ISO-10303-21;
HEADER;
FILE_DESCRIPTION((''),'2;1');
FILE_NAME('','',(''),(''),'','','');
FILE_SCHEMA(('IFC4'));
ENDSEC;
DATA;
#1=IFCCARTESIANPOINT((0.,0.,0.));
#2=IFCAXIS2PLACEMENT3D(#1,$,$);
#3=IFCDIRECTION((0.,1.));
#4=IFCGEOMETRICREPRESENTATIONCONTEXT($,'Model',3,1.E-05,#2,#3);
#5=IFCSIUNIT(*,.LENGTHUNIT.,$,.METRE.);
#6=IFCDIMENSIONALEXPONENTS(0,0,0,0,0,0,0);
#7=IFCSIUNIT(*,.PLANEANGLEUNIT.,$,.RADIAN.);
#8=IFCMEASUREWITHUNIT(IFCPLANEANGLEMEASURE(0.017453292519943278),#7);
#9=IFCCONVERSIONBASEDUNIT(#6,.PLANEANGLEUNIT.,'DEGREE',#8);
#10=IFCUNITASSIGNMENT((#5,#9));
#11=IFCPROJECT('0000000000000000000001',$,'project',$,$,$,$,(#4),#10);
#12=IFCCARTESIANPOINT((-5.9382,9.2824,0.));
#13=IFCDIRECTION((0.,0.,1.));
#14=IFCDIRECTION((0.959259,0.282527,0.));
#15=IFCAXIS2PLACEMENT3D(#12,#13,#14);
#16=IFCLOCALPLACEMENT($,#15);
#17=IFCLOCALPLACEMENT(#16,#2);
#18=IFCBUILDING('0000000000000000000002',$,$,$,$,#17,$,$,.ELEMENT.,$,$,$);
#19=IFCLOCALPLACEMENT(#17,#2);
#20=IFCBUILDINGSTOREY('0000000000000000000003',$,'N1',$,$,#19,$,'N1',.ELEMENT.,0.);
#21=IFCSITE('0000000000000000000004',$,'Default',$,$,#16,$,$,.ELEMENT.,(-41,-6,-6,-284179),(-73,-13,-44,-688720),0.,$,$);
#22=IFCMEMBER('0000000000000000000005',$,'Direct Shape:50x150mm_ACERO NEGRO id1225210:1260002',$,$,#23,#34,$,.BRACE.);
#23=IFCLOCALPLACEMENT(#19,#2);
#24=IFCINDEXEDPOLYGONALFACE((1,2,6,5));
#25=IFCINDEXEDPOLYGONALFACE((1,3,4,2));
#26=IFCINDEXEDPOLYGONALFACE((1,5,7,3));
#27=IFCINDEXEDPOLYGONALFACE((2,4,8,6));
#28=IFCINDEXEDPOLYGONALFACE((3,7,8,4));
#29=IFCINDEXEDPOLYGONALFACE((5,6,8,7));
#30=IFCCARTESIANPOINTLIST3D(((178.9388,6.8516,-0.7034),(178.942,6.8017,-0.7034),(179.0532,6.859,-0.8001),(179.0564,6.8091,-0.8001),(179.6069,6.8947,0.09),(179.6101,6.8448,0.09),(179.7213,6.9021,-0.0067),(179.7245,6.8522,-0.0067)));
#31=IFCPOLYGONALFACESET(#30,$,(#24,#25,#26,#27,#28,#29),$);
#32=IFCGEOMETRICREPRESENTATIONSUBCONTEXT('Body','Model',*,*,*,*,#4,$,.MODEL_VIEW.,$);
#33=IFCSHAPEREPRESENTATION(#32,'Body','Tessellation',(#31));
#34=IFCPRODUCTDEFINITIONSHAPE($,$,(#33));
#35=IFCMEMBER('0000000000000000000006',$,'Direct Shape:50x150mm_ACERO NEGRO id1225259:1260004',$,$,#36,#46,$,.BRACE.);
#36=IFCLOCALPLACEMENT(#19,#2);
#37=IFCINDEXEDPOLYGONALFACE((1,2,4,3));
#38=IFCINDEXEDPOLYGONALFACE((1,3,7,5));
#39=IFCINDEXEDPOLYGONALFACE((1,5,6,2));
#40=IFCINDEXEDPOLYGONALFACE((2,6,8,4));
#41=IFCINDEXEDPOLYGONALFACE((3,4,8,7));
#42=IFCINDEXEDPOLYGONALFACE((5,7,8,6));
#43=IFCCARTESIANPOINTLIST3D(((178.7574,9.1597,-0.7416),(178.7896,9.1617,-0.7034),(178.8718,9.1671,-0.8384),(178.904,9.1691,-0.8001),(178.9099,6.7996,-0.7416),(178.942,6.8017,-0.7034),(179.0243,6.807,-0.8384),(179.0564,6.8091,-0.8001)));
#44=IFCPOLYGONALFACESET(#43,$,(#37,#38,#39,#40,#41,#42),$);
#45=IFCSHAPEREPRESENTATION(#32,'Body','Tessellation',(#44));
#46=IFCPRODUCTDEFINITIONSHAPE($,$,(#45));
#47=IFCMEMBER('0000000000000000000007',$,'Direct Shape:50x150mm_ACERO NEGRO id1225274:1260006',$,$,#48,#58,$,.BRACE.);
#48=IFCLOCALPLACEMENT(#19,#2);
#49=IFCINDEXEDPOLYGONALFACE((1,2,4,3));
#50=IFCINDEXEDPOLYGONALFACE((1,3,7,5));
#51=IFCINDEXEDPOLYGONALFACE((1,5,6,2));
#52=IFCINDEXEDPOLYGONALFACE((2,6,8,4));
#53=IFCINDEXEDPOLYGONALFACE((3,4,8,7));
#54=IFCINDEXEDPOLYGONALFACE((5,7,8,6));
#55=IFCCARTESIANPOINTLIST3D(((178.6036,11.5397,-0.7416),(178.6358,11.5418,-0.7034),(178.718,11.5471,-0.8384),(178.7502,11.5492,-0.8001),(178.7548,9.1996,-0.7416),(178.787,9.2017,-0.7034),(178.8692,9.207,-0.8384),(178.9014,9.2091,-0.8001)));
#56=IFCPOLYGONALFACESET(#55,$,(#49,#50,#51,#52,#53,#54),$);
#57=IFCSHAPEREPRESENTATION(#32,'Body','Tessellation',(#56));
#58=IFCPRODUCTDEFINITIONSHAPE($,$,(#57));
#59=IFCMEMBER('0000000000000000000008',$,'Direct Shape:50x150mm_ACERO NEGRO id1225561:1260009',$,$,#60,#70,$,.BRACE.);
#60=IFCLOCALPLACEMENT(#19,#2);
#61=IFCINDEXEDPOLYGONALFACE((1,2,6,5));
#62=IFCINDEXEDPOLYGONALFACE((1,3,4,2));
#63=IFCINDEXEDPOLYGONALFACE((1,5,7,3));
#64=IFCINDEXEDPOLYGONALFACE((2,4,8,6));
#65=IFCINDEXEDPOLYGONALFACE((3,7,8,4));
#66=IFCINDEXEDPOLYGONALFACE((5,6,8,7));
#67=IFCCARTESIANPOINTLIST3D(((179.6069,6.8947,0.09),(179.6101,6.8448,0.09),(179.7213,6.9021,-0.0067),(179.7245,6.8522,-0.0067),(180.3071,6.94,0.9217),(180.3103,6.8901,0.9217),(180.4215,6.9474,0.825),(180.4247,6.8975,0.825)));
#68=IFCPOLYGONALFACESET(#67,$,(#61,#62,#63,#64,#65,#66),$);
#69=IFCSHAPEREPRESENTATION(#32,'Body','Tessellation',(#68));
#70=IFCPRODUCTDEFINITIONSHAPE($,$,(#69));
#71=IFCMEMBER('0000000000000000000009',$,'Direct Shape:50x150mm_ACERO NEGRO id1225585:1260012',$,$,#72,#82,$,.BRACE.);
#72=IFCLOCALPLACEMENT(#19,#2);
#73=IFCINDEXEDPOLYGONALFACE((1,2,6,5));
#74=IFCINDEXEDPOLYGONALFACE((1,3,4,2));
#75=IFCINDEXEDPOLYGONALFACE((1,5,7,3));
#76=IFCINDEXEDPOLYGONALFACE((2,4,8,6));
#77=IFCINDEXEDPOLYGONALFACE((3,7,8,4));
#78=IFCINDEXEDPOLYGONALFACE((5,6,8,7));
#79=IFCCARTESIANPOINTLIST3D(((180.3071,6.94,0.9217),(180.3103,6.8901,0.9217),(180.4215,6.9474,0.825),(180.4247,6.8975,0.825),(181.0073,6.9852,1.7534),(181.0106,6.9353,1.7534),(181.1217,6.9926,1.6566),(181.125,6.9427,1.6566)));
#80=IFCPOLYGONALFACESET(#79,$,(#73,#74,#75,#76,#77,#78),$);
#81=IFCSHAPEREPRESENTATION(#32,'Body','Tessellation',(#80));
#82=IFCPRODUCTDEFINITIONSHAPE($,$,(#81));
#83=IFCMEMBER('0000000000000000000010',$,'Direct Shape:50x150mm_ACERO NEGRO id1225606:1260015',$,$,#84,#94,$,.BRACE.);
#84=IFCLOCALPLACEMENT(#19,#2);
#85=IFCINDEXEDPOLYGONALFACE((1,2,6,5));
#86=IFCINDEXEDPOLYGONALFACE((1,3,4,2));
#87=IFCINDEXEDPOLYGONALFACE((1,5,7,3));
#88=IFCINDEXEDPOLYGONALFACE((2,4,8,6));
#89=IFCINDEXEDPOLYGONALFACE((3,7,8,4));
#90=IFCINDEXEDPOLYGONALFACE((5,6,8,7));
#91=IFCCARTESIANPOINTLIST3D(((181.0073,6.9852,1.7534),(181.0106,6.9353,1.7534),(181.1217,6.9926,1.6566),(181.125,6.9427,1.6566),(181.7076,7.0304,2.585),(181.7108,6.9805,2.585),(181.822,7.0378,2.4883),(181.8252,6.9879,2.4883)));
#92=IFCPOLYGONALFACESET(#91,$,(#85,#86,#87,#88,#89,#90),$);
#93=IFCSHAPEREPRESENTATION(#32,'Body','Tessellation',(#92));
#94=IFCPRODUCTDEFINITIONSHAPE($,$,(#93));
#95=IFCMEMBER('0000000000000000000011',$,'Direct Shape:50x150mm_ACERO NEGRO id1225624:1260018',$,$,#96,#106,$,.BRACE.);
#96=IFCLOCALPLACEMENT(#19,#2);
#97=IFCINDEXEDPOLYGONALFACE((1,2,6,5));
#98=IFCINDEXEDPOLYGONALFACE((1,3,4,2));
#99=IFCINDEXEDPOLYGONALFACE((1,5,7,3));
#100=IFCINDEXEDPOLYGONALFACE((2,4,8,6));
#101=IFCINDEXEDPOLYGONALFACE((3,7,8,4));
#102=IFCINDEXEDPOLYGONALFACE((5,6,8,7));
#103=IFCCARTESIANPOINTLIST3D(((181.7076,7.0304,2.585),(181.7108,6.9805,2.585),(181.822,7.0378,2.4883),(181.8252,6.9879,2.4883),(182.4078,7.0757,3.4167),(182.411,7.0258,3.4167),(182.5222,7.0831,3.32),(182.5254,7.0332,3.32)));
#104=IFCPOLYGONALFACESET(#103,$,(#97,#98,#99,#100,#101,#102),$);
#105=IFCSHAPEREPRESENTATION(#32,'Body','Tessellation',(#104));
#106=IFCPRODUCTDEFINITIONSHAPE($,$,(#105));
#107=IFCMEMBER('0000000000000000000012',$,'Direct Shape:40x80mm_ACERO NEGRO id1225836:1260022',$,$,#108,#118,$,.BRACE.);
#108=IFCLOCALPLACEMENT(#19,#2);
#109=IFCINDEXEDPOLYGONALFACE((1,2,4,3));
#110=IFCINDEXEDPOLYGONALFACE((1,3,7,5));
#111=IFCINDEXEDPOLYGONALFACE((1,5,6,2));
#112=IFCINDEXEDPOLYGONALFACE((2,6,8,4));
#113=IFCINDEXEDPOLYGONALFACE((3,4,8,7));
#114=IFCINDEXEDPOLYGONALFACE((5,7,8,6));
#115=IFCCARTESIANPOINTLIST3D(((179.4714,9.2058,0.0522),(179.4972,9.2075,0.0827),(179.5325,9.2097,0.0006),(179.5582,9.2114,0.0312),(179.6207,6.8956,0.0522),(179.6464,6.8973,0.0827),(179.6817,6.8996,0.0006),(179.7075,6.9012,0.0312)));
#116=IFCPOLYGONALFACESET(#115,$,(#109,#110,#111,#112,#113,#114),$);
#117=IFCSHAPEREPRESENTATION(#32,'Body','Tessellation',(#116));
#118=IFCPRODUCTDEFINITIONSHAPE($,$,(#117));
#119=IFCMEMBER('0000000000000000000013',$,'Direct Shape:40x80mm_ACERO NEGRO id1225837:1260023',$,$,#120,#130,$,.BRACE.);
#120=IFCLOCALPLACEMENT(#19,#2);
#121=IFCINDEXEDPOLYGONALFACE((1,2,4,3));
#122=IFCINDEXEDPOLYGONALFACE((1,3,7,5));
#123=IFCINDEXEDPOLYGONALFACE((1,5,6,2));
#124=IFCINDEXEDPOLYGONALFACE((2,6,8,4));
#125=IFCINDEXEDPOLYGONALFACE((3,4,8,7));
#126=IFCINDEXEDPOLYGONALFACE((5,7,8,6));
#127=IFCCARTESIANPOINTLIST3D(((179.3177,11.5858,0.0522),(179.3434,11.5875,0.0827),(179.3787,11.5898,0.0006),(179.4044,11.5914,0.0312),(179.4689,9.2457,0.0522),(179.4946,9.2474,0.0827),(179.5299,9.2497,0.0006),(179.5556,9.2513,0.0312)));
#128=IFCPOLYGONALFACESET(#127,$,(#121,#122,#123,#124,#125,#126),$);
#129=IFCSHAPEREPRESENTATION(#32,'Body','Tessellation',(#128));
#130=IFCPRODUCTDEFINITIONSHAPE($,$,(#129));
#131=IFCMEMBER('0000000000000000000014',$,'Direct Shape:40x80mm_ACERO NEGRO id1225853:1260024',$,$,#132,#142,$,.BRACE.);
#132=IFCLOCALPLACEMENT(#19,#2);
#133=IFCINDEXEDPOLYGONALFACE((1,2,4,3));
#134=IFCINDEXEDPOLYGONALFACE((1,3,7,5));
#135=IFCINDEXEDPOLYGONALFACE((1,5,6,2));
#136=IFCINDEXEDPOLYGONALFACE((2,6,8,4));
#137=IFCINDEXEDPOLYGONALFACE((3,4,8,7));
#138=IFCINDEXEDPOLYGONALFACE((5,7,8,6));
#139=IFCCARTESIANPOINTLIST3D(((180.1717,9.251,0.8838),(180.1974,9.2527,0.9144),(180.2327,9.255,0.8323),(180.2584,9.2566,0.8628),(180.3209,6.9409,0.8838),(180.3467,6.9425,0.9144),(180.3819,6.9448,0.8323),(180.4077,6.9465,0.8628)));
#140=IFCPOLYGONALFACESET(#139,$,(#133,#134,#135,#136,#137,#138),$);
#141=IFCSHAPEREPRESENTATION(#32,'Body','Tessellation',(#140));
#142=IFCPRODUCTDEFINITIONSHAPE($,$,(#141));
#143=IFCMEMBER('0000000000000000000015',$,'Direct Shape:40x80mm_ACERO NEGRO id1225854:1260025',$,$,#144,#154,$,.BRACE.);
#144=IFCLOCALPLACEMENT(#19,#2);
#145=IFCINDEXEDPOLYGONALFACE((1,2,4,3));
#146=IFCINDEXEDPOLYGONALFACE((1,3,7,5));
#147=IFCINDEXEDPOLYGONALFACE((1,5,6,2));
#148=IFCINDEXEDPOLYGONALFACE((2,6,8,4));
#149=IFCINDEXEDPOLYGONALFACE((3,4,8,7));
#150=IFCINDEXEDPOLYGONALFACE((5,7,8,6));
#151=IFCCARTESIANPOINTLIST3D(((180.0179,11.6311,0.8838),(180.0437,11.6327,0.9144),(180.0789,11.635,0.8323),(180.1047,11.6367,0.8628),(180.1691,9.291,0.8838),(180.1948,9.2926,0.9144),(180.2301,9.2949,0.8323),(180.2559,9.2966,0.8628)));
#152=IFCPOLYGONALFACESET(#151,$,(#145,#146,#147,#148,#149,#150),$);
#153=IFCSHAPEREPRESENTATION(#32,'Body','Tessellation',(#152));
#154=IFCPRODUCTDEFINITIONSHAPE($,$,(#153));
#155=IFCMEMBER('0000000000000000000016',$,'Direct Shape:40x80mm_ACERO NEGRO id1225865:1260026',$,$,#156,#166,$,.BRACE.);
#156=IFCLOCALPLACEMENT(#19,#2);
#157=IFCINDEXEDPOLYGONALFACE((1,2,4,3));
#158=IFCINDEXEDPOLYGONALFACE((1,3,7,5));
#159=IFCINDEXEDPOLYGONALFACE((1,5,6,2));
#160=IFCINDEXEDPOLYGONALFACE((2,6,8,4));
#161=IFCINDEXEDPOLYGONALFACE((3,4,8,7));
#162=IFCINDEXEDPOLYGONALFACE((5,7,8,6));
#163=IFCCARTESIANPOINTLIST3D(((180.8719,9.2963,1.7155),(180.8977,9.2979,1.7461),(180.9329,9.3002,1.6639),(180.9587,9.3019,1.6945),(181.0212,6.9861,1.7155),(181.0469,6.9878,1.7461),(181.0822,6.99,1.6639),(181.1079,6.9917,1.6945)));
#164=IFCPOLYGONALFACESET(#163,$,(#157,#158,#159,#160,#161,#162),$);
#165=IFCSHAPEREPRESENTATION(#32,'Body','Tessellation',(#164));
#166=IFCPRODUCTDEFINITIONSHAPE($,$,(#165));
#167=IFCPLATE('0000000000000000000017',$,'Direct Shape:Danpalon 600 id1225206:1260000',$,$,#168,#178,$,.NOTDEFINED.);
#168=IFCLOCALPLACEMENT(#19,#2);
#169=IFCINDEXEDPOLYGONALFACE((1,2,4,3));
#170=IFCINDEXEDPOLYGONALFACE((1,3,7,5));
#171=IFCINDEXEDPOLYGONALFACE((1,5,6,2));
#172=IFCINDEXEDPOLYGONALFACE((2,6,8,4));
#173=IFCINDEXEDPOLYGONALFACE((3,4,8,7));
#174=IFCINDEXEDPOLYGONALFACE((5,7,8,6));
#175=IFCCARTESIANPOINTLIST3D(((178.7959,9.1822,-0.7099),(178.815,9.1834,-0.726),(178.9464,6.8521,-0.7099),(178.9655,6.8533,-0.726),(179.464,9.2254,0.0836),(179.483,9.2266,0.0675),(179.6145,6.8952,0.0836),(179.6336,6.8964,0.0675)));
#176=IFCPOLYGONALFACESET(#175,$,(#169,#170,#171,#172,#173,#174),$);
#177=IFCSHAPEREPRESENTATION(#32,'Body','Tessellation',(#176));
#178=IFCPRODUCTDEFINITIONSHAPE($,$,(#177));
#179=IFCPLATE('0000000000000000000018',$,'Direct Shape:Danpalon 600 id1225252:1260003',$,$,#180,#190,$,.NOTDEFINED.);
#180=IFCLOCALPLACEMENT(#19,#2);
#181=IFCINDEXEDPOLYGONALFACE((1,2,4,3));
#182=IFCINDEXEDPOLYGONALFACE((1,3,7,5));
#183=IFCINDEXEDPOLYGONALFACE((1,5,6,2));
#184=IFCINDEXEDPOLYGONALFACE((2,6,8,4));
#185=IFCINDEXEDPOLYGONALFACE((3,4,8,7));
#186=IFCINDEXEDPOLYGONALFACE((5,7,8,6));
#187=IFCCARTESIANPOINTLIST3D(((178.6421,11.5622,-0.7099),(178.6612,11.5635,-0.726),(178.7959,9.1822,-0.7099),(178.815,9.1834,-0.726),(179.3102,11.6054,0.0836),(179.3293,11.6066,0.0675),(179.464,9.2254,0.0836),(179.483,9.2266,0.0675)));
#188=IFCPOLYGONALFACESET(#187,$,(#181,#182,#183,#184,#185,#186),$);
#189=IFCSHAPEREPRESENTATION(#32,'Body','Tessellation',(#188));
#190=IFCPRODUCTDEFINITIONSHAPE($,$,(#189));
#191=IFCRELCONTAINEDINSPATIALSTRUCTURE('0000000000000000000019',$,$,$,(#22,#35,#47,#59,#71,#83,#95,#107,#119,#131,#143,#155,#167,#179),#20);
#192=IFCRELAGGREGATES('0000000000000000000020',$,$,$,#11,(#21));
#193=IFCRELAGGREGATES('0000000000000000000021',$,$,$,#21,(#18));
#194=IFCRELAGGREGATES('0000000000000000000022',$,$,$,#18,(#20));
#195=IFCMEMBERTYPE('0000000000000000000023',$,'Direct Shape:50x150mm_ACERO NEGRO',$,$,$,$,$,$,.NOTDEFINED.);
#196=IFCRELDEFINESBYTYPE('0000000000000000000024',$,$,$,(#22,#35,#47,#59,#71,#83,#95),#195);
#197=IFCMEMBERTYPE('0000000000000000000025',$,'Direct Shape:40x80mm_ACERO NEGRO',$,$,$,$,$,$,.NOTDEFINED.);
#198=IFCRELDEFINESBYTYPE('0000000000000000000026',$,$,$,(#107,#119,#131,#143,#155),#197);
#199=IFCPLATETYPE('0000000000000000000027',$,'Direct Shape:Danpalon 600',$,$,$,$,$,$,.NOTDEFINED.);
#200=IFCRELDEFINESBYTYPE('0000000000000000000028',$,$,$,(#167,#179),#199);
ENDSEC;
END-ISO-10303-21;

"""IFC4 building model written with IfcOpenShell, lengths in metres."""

from ifc_helpers import new_model, entity, si_unit, converted_unit, direction, frame, frame_2d, origin, origin_2d_with_axis, place, context, subcontext, project, spatial, rectangle, extrude, type_object, element, save


model = new_model("IFC4")

# Units and contexts
model_context = context("Model", 3, precision=1e-05, world=origin(), true_north=direction((0.0, 1.0)))
body_context = subcontext(model_context, "Body", "Model", "MODEL_VIEW")
ifc_project = project(units=[si_unit("LENGTHUNIT", "METRE"), converted_unit("PLANEANGLEUNIT", "DEGREE", entity("IfcPlaneAngleMeasure", 0.017453292519943278), si_unit("PLANEANGLEUNIT", "RADIAN"), dimensions=[0, 0, 0, 0, 0, 0, 0])], contexts=[model_context])

# Site, building, storey
site_placement = place(None, frame((-5.9382, 9.2824, 0.0), z_axis=(0.0, 0.0, 1.0), x_axis=(0.959259, 0.282527, 0.0)))
site = spatial("IfcSite", under=ifc_project, at=site_placement, Name="Default", CompositionType="ELEMENT", RefLatitude=(-41, -6, -6, -284179), RefLongitude=(-73, -13, -44, -688720), RefElevation=0.0)
building_placement = place(site_placement, origin())
building = spatial("IfcBuilding", under=site, at=building_placement, CompositionType="ELEMENT")
storey_placement = place(building_placement, origin())
storey = spatial("IfcBuildingStorey", under=building, at=storey_placement, Name="N1", LongName="N1", CompositionType="ELEMENT", Elevation=0.0)

# Members
member_type_1 = type_object("IfcMemberType", Name="Direct Shape:50x150mm_ACERO NEGRO", PredefinedType="NOTDEFINED")
member_1_placement = place(storey_placement, origin())
element("IfcMember", 1, at=member_1_placement, inside=storey, type_object=member_type_1, Name="Direct Shape:50x150mm_ACERO NEGRO id1225210:1260002", PredefinedType="BRACE", context=body_context, shape_type="SweptSolid", body=[
    extrude(rectangle(XDim=0.15, YDim=0.05, at=frame_2d((0.0, 0.0), x_axis=(1.0, 0.0))), frame((178.9976, 6.8303, -0.7518), z_axis=(0.643515, 0.041575, 0.764304), x_axis=(0.762714, 0.049276, -0.644857)), (0.0, 0.0, 1.0), 1.0381),
])
member_2_placement = place(storey_placement, origin())
element("IfcMember", 2, at=member_2_placement, inside=storey, type_object=member_type_1, Name="Direct Shape:50x150mm_ACERO NEGRO id1225259:1260004", PredefinedType="BRACE", context=body_context, shape_type="SweptSolid", body=[
    extrude(rectangle(XDim=0.05, YDim=0.15, at=frame_2d((0.0, 0.0), x_axis=(1.0, 0.0))), frame((178.9832, 6.8043, -0.7709), z_axis=(-0.064471, 0.99792, 0.0), x_axis=(0.643515, 0.041575, 0.764304)), (0.0, 0.0, 1.0), 2.365),
])
member_3_placement = place(storey_placement, origin())
element("IfcMember", 3, at=member_3_placement, inside=storey, type_object=member_type_1, Name="Direct Shape:50x150mm_ACERO NEGRO id1225274:1260006", PredefinedType="BRACE", context=body_context, shape_type="SweptSolid", body=[
    extrude(rectangle(XDim=0.05, YDim=0.15, at=origin_2d_with_axis()), frame((178.8281, 9.2043, -0.7709), z_axis=(-0.064471, 0.99792, 0.0), x_axis=(0.643515, 0.041575, 0.764304)), (0.0, 0.0, 1.0), 2.345),
])
member_4_placement = place(storey_placement, origin())
element("IfcMember", 4, at=member_4_placement, inside=storey, type_object=member_type_1, Name="Direct Shape:50x150mm_ACERO NEGRO id1225561:1260009", PredefinedType="BRACE", context=body_context, shape_type="SweptSolid", body=[
    extrude(rectangle(XDim=0.15, YDim=0.05, at=frame_2d((0.0, 0.0), x_axis=(1.0, 0.0))), frame((179.6657, 6.8735, 0.0417), z_axis=(0.643515, 0.041575, 0.764304), x_axis=(0.762714, 0.049276, -0.644857)), (0.0, 0.0, 1.0), 1.0881),
])
member_5_placement = place(storey_placement, origin())
element("IfcMember", 5, at=member_5_placement, inside=storey, type_object=member_type_1, Name="Direct Shape:50x150mm_ACERO NEGRO id1225585:1260012", PredefinedType="BRACE", context=body_context, shape_type="SweptSolid", body=[
    extrude(rectangle(XDim=0.15, YDim=0.05, at=frame_2d((0.0, 0.0), x_axis=(1.0, 0.0))), frame((180.3659, 6.9187, 0.8733), z_axis=(0.643515, 0.041575, 0.764304), x_axis=(0.762714, 0.049276, -0.644857)), (0.0, 0.0, 1.0), 1.0881),
])
member_6_placement = place(storey_placement, origin())
element("IfcMember", 6, at=member_6_placement, inside=storey, type_object=member_type_1, Name="Direct Shape:50x150mm_ACERO NEGRO id1225606:1260015", PredefinedType="BRACE", context=body_context, shape_type="SweptSolid", body=[
    extrude(rectangle(XDim=0.15, YDim=0.05, at=frame_2d((0.0, 0.0), x_axis=(1.0, 0.0))), frame((181.0662, 6.964, 1.705), z_axis=(0.643515, 0.041575, 0.764304), x_axis=(0.762714, 0.049276, -0.644857)), (0.0, 0.0, 1.0), 1.0881),
])
member_7_placement = place(storey_placement, origin())
element("IfcMember", 7, at=member_7_placement, inside=storey, type_object=member_type_1, Name="Direct Shape:50x150mm_ACERO NEGRO id1225624:1260018", PredefinedType="BRACE", context=body_context, shape_type="SweptSolid", body=[
    extrude(rectangle(XDim=0.15, YDim=0.05, at=frame_2d((0.0, 0.0), x_axis=(1.0, 0.0))), frame((181.7664, 7.0092, 2.5367), z_axis=(0.643515, 0.041575, 0.764304), x_axis=(0.762714, 0.049276, -0.644857)), (0.0, 0.0, 1.0), 1.0881),
])
member_type_2 = type_object("IfcMemberType", Name="Direct Shape:40x80mm_ACERO NEGRO", PredefinedType="NOTDEFINED")
member_8_placement = place(storey_placement, origin())
element("IfcMember", 8, at=member_8_placement, inside=storey, type_object=member_type_2, Name="Direct Shape:40x80mm_ACERO NEGRO id1225836:1260022", PredefinedType="BRACE", context=body_context, shape_type="SweptSolid", body=[
    extrude(rectangle(XDim=0.04, YDim=0.08, at=frame_2d((0.0, 0.0), x_axis=(0.0, 1.0))), frame((179.6641, 6.8984, 0.0417), z_axis=(-0.064471, 0.99792, 0.0), x_axis=(0.762714, 0.049276, -0.644857)), (0.0, 0.0, 1.0), 2.315),
])
member_9_placement = place(storey_placement, origin())
element("IfcMember", 9, at=member_9_placement, inside=storey, type_object=member_type_2, Name="Direct Shape:40x80mm_ACERO NEGRO id1225837:1260023", PredefinedType="BRACE", context=body_context, shape_type="SweptSolid", body=[
    extrude(rectangle(XDim=0.04, YDim=0.08, at=frame_2d((0.0, 0.0), x_axis=(0.0, 1.0))), frame((179.5122, 9.2485, 0.0417), z_axis=(-0.064471, 0.99792, 0.0), x_axis=(0.762714, 0.049276, -0.644857)), (0.0, 0.0, 1.0), 2.345),
])
member_10_placement = place(storey_placement, origin())
element("IfcMember", 10, at=member_10_placement, inside=storey, type_object=member_type_2, Name="Direct Shape:40x80mm_ACERO NEGRO id1225853:1260024", PredefinedType="BRACE", context=body_context, shape_type="SweptSolid", body=[
    extrude(rectangle(XDim=0.04, YDim=0.08, at=frame_2d((0.0, 0.0), x_axis=(0.0, 1.0))), frame((180.3643, 6.9437, 0.8733), z_axis=(-0.064471, 0.99792, 0.0), x_axis=(0.762714, 0.049276, -0.644857)), (0.0, 0.0, 1.0), 2.315),
])
member_11_placement = place(storey_placement, origin())
element("IfcMember", 11, at=member_11_placement, inside=storey, type_object=member_type_2, Name="Direct Shape:40x80mm_ACERO NEGRO id1225854:1260025", PredefinedType="BRACE", context=body_context, shape_type="SweptSolid", body=[
    extrude(rectangle(XDim=0.04, YDim=0.08, at=frame_2d((0.0, 0.0), x_axis=(0.0, 1.0))), frame((180.2125, 9.2938, 0.8733), z_axis=(-0.064471, 0.99792, 0.0), x_axis=(0.762714, 0.049276, -0.644857)), (0.0, 0.0, 1.0), 2.345),
])
member_12_placement = place(storey_placement, origin())
element("IfcMember", 12, at=member_12_placement, inside=storey, type_object=member_type_2, Name="Direct Shape:40x80mm_ACERO NEGRO id1225865:1260026", PredefinedType="BRACE", context=body_context, shape_type="SweptSolid", body=[
    extrude(rectangle(XDim=0.04, YDim=0.08, at=frame_2d((0.0, 0.0), x_axis=(0.0, 1.0))), frame((181.0645, 6.9889, 1.705), z_axis=(-0.064471, 0.99792, 0.0), x_axis=(0.762714, 0.049276, -0.644857)), (0.0, 0.0, 1.0), 2.315),
])

# Plates
plate_type = type_object("IfcPlateType", Name="Direct Shape:Danpalon 600", PredefinedType="NOTDEFINED")
plate_1_placement = place(storey_placement, origin())
element("IfcPlate", 13, at=plate_1_placement, inside=storey, type_object=plate_type, Name="Direct Shape:Danpalon 600 id1225206:1260000", PredefinedType="NOTDEFINED", context=body_context, shape_type="SweptSolid", body=[
    extrude(rectangle(XDim=1.0381, YDim=0.025, at=frame_2d((0.0, 0.0), x_axis=(0.0, 1.0))), frame((179.29, 6.8743, -0.3212), z_axis=(-0.064471, 0.99792, 0.0), x_axis=(-0.762714, -0.049276, 0.644857)), (0.0, 0.0, 1.0), 2.335),
])
plate_2_placement = place(storey_placement, origin())
element("IfcPlate", 14, at=plate_2_placement, inside=storey, type_object=plate_type, Name="Direct Shape:Danpalon 600 id1225252:1260003", PredefinedType="NOTDEFINED", context=body_context, shape_type="SweptSolid", body=[
    extrude(rectangle(XDim=1.0381, YDim=0.025, at=frame_2d((0.0, 0.0), x_axis=(0.0, 1.0))), frame((179.1395, 9.2044, -0.3212), z_axis=(-0.064471, 0.99792, 0.0), x_axis=(-0.762714, -0.049276, 0.644857)), (0.0, 0.0, 1.0), 2.385),
])

save(model, "model.ifc")
